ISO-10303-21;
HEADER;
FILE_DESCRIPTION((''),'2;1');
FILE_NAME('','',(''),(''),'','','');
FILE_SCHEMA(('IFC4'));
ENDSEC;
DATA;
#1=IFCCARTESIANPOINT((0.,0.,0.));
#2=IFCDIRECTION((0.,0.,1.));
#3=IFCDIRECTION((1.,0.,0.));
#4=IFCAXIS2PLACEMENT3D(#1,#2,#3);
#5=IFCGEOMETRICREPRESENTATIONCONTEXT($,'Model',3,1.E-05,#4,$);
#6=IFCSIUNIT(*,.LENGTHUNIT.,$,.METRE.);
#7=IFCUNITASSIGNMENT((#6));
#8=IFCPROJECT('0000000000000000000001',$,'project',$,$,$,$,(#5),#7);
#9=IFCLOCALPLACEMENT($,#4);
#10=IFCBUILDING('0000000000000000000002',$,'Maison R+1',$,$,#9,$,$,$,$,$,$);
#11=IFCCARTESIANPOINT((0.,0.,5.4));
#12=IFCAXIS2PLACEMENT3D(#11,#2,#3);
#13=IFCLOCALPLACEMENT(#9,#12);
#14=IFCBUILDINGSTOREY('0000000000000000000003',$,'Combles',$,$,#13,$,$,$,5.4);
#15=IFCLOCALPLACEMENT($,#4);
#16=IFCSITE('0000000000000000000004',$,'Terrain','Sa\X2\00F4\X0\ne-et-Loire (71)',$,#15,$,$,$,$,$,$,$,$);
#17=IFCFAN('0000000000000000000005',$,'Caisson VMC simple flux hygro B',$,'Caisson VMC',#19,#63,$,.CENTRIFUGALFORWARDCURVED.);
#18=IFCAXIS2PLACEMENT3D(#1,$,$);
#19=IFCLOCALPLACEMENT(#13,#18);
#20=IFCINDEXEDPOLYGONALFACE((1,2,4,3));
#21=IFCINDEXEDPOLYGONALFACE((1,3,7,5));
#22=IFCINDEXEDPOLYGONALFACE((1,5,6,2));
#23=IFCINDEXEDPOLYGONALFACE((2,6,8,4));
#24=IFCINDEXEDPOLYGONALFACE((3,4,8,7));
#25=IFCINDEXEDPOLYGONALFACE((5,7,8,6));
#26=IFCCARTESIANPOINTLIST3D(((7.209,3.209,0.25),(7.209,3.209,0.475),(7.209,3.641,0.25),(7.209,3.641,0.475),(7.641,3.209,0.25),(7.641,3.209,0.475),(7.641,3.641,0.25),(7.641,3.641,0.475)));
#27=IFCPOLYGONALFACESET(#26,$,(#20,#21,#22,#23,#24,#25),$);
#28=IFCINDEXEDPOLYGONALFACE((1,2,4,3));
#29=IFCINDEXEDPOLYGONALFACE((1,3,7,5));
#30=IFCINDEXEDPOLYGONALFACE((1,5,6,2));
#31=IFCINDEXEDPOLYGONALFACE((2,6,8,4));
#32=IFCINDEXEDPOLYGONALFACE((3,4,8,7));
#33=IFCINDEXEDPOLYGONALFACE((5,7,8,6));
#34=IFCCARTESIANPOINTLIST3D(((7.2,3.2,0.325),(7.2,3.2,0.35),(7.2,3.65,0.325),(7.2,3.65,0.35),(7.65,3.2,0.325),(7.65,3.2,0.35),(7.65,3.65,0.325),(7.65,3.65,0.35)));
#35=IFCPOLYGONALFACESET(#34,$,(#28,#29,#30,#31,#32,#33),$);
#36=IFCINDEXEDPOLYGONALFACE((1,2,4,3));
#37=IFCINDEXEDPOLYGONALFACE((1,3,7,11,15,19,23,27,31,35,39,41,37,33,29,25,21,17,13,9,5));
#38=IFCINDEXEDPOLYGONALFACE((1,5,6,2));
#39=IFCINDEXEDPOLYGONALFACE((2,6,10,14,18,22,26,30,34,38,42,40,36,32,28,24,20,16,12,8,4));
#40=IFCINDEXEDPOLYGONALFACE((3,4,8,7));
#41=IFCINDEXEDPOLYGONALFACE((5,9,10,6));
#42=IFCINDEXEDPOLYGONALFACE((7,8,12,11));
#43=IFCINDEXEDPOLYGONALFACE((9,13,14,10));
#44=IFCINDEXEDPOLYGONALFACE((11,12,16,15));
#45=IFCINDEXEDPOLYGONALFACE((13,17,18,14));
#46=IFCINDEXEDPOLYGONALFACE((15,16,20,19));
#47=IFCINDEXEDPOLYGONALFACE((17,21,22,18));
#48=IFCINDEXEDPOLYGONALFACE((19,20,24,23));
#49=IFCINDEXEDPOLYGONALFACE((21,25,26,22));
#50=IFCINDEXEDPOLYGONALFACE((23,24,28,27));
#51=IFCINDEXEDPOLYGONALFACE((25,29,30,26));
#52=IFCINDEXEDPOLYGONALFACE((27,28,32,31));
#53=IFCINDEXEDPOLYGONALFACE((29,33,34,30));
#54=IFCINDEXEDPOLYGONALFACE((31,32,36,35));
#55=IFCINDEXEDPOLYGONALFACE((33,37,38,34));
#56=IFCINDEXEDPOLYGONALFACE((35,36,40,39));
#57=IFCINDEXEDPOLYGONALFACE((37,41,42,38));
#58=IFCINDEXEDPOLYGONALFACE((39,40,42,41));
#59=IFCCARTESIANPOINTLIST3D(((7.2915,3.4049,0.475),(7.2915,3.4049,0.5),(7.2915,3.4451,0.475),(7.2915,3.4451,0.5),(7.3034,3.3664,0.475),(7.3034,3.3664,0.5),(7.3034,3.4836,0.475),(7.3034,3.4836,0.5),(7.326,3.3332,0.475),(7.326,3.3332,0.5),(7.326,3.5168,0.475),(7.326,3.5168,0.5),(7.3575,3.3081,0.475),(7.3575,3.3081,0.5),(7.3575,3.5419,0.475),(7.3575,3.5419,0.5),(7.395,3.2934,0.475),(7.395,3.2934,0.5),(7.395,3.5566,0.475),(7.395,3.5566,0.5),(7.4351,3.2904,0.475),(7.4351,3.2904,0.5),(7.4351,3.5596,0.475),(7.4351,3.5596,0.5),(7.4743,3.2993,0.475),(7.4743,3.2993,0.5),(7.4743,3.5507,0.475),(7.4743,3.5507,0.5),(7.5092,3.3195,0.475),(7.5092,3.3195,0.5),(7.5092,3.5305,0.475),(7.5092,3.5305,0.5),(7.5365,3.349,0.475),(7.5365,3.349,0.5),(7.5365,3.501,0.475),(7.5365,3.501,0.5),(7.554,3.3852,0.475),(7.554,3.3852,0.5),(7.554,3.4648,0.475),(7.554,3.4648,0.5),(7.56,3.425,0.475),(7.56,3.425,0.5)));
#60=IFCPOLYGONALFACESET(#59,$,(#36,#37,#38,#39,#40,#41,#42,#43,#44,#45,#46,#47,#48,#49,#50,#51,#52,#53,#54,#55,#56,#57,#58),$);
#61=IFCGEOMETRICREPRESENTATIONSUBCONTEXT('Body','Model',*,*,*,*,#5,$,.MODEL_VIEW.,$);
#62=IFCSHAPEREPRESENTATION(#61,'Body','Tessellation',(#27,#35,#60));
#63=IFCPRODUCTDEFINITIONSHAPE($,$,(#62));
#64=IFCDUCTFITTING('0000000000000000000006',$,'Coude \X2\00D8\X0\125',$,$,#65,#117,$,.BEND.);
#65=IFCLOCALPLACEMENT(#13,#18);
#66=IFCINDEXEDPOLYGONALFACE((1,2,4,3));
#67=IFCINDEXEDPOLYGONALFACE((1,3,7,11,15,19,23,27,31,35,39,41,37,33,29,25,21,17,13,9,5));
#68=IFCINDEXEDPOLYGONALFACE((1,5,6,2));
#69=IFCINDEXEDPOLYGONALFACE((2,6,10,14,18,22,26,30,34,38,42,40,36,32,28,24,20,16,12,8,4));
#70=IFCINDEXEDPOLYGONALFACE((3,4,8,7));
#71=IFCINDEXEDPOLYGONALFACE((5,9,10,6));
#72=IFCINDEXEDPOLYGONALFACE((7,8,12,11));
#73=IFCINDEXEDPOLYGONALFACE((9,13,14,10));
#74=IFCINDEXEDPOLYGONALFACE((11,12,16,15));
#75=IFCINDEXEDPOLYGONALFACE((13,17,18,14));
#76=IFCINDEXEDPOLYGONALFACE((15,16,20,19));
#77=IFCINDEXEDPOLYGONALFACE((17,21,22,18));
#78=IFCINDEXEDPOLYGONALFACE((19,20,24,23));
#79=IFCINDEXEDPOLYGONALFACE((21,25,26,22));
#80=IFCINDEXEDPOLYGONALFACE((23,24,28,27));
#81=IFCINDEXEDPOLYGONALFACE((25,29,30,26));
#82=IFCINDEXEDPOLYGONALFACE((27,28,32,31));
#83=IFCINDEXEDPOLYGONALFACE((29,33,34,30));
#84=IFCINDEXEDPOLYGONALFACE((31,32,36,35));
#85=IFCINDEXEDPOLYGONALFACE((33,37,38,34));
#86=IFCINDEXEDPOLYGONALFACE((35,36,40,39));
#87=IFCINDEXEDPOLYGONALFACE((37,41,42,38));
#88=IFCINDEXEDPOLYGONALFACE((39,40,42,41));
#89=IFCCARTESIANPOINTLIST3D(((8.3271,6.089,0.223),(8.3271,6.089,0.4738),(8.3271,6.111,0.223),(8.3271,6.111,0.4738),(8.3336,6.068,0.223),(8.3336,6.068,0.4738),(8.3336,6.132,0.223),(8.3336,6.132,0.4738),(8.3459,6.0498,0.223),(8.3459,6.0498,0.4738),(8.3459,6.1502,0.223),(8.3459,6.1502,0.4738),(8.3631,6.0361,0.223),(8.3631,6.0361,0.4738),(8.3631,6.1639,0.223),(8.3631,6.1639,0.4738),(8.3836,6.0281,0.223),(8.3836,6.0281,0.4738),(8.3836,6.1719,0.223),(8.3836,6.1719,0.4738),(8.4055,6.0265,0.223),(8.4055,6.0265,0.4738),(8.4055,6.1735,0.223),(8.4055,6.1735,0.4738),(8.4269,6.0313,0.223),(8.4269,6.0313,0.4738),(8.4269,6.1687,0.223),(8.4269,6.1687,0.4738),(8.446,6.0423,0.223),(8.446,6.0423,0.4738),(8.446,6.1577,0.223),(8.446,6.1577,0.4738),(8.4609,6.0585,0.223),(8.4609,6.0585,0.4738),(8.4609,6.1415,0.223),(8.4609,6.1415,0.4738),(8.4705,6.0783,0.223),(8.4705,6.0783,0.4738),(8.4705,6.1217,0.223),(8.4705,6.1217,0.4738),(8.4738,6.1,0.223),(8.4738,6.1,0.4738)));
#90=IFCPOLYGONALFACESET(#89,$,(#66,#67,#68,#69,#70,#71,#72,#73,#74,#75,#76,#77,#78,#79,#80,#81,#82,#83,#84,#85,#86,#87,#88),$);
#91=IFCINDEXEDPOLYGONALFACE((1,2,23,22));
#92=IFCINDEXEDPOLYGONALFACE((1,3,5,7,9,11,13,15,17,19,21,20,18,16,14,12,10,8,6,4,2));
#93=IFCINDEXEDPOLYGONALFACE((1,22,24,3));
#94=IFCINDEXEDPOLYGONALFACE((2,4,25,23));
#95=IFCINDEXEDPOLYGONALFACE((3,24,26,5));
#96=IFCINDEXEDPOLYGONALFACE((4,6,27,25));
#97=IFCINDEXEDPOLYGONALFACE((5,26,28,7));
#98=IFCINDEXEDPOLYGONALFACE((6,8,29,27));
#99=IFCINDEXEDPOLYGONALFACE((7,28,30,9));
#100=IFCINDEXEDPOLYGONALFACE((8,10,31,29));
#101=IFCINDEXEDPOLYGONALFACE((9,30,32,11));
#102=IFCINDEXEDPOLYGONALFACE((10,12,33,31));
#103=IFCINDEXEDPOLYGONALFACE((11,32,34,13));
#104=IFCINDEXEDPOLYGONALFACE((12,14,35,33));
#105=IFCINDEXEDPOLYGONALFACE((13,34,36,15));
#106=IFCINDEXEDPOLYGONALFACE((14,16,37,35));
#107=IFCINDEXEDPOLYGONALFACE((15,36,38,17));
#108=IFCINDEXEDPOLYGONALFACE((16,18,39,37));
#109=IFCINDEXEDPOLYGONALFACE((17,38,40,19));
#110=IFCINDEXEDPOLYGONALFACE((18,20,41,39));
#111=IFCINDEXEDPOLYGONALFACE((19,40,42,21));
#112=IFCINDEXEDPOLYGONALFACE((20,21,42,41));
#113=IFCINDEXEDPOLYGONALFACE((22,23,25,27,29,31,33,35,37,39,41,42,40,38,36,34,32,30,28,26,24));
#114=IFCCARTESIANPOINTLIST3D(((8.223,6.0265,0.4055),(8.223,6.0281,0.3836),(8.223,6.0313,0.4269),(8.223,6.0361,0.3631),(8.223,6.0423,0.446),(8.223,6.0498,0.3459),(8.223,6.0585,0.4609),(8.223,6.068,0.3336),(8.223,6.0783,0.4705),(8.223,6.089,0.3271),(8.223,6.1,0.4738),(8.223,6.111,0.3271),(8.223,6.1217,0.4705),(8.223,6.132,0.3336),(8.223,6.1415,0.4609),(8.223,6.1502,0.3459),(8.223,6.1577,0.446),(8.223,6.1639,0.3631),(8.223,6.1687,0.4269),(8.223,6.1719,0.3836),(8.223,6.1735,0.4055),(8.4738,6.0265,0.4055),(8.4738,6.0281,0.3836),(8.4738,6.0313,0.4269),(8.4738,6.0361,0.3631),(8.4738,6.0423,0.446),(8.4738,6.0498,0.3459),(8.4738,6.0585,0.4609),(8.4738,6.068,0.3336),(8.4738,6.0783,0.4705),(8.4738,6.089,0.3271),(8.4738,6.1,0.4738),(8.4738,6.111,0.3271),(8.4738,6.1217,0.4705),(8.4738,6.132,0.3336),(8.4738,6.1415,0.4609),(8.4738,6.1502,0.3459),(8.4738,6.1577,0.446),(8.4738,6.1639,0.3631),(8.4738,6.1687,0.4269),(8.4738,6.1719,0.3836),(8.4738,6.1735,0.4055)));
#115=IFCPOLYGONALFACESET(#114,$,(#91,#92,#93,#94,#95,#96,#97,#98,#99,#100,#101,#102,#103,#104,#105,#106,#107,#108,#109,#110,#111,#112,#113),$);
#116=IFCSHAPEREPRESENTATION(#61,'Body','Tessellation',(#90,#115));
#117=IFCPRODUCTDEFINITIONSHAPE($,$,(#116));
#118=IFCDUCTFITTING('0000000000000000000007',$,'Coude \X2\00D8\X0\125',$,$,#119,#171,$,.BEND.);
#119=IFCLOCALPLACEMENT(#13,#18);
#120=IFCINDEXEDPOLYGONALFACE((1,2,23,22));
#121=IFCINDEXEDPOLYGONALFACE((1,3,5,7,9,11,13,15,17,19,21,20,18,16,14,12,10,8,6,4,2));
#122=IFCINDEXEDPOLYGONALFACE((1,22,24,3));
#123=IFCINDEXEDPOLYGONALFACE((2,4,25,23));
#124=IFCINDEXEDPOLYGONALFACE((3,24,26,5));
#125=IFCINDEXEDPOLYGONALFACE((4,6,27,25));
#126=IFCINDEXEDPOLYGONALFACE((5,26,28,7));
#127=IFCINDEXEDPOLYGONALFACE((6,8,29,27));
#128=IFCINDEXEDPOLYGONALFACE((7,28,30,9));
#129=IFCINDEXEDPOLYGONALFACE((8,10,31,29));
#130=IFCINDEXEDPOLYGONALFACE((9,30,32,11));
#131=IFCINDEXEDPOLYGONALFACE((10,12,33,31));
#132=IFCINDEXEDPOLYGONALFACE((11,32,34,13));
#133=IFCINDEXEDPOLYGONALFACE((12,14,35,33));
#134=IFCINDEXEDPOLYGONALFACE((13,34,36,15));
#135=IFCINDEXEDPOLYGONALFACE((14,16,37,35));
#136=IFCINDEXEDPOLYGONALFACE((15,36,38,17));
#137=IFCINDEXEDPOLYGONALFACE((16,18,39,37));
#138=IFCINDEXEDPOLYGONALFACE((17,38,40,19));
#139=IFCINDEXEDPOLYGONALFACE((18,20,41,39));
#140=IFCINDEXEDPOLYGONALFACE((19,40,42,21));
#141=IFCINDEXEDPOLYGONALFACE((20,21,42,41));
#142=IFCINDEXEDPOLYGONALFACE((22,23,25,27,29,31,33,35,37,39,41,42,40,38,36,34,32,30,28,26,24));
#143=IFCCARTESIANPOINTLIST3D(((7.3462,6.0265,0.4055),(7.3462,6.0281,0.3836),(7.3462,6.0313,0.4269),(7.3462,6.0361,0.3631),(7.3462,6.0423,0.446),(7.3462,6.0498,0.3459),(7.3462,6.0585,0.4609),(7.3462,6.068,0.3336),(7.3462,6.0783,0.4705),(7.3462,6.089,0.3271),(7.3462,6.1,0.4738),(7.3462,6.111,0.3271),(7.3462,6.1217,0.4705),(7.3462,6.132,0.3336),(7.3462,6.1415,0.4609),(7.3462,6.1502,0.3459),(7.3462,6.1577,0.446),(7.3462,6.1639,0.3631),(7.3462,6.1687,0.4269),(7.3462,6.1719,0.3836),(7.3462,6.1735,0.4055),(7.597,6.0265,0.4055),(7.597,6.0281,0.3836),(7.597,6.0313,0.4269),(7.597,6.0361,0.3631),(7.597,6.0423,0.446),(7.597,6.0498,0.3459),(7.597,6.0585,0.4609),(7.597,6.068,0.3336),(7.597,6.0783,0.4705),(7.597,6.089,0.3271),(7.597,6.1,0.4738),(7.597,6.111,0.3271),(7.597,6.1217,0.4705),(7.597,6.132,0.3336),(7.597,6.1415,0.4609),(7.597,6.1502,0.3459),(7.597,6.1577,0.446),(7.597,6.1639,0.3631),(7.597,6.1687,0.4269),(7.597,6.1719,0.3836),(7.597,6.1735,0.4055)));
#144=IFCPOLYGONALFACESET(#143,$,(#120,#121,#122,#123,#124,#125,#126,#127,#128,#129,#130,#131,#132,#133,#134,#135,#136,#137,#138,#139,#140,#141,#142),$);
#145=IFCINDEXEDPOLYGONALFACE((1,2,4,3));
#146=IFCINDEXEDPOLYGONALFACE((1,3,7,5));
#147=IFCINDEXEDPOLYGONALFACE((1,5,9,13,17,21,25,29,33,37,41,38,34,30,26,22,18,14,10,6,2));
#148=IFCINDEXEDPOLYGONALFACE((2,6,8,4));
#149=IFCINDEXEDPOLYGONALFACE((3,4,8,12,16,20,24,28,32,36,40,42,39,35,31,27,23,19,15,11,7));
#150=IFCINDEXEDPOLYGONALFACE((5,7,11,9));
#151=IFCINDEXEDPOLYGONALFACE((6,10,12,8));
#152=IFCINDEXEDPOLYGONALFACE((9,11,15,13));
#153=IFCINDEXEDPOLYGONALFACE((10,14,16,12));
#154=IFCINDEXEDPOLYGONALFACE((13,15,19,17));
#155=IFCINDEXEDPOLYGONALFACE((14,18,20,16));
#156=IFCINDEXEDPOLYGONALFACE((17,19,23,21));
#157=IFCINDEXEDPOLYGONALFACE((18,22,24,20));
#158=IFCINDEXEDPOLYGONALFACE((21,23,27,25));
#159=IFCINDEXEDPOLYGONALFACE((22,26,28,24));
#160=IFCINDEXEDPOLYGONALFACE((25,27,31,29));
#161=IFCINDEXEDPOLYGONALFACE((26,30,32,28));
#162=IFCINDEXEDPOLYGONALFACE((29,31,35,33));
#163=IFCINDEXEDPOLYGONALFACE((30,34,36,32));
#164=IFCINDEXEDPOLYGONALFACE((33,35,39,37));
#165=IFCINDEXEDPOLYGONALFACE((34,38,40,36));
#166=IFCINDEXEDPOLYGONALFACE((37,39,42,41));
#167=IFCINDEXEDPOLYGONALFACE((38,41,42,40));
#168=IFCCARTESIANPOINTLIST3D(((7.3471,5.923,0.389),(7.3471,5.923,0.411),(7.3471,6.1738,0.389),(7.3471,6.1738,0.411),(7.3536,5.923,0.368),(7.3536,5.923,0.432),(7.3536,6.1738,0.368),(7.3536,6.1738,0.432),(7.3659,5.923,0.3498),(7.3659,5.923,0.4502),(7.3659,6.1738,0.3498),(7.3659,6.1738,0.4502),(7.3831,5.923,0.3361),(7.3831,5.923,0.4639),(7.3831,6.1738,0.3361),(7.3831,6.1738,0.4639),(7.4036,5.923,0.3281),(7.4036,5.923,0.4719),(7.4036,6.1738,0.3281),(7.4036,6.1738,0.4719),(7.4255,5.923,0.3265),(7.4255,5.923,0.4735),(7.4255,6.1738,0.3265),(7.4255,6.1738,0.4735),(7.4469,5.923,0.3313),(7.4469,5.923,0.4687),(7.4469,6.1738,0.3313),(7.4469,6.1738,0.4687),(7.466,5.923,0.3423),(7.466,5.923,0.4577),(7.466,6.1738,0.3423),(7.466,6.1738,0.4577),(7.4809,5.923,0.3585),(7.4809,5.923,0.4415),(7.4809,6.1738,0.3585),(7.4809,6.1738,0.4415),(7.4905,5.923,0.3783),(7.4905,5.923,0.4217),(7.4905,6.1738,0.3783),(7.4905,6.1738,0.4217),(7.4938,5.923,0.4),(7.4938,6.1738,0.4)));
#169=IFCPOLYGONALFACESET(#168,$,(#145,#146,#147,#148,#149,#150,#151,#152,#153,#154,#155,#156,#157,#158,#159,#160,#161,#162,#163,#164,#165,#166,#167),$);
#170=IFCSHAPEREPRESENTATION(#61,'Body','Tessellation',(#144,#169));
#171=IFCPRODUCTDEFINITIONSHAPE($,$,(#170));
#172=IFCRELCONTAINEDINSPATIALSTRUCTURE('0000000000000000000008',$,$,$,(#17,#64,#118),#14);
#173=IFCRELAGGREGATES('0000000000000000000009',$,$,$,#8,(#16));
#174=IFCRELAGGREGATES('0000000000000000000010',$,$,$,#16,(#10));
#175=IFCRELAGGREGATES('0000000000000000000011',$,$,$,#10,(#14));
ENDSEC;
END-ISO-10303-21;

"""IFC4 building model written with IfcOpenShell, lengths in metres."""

from ifc_helpers import new_model, si_unit, frame, frame_2d, origin_with_axes, place, context, subcontext, project, spatial, rectangle, circle, extrude, element, save


model = new_model("IFC4")

# Units and contexts
model_context = context("Model", 3, precision=1e-05, world=origin_with_axes())
body_context = subcontext(model_context, "Body", "Model", "MODEL_VIEW")
ifc_project = project(units=[si_unit("LENGTHUNIT", "METRE")], contexts=[model_context])

# Site, building, storey
site_placement = place(None, origin_with_axes())
site = spatial("IfcSite", under=ifc_project, at=site_placement, Name="Terrain", Description="Saône-et-Loire (71)")
building_placement = place(None, origin_with_axes())
building = spatial("IfcBuilding", under=site, at=building_placement, Name="Maison R+1")
storey_placement = place(building_placement, frame((0.0, 0.0, 5.4), z_axis=(0.0, 0.0, 1.0), x_axis=(1.0, 0.0, 0.0)))
storey = spatial("IfcBuildingStorey", under=building, at=storey_placement, Name="Combles", Elevation=5.4)

# Fan
fan_placement = place(storey_placement, frame((7.2, 3.2, 0.25), z_axis=(0.0, 0.0, 1.0), x_axis=(1.0, 0.0, 0.0)))
element("IfcFan", 1, at=fan_placement, inside=storey, Name="Caisson VMC simple flux hygro B", ObjectType="Caisson VMC", PredefinedType="CENTRIFUGALFORWARDCURVED", context=body_context, shape_type="SweptSolid", body=[
    extrude(rectangle(XDim=0.432, YDim=0.432, at=frame_2d((0.216, 0.216))), frame((0.009, 0.009, 0.0), z_axis=(0.0, 0.0, 1.0), x_axis=(1.0, 0.0, 0.0)), (0.0, 0.0, 1.0), 0.225),
    extrude(rectangle(XDim=0.45, YDim=0.45, at=frame_2d((0.225, 0.225))), frame((0.0, 0.0, 0.075), z_axis=(0.0, 0.0, 1.0), x_axis=(1.0, 0.0, 0.0)), (0.0, 0.0, 1.0), 0.025),
    extrude(circle(Radius=0.135), frame((0.225, 0.225, 0.225), z_axis=(0.0, 0.0, 1.0), x_axis=(1.0, 0.0, 0.0)), (0.0, 0.0, 1.0), 0.025),
])

# Duct fittings
duct_fitting_1_placement = place(storey_placement, frame((8.4, 6.1, 0.4), z_axis=(0.0, 0.0, 1.0), x_axis=(1.0, 0.0, 0.0)))
element("IfcDuctFitting", 2, at=duct_fitting_1_placement, inside=storey, Name="Coude Ø125", PredefinedType="BEND", context=body_context, shape_type="SweptSolid", body=[
    extrude(circle(Radius=0.0737), frame((0.0, 0.0, 0.0737), z_axis=(0.0, 0.0, -1.0), x_axis=(1.0, 0.0, 0.0)), (0.0, 0.0, 1.0), 0.2507),
    extrude(circle(Radius=0.0737), frame((0.0737, 0.0, 0.0), z_axis=(-1.0, 0.0, 0.0), x_axis=(0.0, 0.0, 1.0)), (0.0, 0.0, 1.0), 0.2507),
])
duct_fitting_2_placement = place(storey_placement, frame((7.42, 6.1, 0.4), z_axis=(0.0, 0.0, 1.0), x_axis=(1.0, 0.0, 0.0)))
element("IfcDuctFitting", 3, at=duct_fitting_2_placement, inside=storey, Name="Coude Ø125", PredefinedType="BEND", context=body_context, shape_type="SweptSolid", body=[
    extrude(circle(Radius=0.0737), frame((-0.0737, 0.0, 0.0), z_axis=(1.0, 0.0, 0.0), x_axis=(0.0, 0.0, 1.0)), (0.0, 0.0, 1.0), 0.2507),
    extrude(circle(Radius=0.0737), frame((0.0, 0.0737, 0.0), z_axis=(0.0, -1.0, 0.0), x_axis=(1.0, 0.0, 0.0)), (0.0, 0.0, 1.0), 0.2507),
])

save(model, "model.ifc")
